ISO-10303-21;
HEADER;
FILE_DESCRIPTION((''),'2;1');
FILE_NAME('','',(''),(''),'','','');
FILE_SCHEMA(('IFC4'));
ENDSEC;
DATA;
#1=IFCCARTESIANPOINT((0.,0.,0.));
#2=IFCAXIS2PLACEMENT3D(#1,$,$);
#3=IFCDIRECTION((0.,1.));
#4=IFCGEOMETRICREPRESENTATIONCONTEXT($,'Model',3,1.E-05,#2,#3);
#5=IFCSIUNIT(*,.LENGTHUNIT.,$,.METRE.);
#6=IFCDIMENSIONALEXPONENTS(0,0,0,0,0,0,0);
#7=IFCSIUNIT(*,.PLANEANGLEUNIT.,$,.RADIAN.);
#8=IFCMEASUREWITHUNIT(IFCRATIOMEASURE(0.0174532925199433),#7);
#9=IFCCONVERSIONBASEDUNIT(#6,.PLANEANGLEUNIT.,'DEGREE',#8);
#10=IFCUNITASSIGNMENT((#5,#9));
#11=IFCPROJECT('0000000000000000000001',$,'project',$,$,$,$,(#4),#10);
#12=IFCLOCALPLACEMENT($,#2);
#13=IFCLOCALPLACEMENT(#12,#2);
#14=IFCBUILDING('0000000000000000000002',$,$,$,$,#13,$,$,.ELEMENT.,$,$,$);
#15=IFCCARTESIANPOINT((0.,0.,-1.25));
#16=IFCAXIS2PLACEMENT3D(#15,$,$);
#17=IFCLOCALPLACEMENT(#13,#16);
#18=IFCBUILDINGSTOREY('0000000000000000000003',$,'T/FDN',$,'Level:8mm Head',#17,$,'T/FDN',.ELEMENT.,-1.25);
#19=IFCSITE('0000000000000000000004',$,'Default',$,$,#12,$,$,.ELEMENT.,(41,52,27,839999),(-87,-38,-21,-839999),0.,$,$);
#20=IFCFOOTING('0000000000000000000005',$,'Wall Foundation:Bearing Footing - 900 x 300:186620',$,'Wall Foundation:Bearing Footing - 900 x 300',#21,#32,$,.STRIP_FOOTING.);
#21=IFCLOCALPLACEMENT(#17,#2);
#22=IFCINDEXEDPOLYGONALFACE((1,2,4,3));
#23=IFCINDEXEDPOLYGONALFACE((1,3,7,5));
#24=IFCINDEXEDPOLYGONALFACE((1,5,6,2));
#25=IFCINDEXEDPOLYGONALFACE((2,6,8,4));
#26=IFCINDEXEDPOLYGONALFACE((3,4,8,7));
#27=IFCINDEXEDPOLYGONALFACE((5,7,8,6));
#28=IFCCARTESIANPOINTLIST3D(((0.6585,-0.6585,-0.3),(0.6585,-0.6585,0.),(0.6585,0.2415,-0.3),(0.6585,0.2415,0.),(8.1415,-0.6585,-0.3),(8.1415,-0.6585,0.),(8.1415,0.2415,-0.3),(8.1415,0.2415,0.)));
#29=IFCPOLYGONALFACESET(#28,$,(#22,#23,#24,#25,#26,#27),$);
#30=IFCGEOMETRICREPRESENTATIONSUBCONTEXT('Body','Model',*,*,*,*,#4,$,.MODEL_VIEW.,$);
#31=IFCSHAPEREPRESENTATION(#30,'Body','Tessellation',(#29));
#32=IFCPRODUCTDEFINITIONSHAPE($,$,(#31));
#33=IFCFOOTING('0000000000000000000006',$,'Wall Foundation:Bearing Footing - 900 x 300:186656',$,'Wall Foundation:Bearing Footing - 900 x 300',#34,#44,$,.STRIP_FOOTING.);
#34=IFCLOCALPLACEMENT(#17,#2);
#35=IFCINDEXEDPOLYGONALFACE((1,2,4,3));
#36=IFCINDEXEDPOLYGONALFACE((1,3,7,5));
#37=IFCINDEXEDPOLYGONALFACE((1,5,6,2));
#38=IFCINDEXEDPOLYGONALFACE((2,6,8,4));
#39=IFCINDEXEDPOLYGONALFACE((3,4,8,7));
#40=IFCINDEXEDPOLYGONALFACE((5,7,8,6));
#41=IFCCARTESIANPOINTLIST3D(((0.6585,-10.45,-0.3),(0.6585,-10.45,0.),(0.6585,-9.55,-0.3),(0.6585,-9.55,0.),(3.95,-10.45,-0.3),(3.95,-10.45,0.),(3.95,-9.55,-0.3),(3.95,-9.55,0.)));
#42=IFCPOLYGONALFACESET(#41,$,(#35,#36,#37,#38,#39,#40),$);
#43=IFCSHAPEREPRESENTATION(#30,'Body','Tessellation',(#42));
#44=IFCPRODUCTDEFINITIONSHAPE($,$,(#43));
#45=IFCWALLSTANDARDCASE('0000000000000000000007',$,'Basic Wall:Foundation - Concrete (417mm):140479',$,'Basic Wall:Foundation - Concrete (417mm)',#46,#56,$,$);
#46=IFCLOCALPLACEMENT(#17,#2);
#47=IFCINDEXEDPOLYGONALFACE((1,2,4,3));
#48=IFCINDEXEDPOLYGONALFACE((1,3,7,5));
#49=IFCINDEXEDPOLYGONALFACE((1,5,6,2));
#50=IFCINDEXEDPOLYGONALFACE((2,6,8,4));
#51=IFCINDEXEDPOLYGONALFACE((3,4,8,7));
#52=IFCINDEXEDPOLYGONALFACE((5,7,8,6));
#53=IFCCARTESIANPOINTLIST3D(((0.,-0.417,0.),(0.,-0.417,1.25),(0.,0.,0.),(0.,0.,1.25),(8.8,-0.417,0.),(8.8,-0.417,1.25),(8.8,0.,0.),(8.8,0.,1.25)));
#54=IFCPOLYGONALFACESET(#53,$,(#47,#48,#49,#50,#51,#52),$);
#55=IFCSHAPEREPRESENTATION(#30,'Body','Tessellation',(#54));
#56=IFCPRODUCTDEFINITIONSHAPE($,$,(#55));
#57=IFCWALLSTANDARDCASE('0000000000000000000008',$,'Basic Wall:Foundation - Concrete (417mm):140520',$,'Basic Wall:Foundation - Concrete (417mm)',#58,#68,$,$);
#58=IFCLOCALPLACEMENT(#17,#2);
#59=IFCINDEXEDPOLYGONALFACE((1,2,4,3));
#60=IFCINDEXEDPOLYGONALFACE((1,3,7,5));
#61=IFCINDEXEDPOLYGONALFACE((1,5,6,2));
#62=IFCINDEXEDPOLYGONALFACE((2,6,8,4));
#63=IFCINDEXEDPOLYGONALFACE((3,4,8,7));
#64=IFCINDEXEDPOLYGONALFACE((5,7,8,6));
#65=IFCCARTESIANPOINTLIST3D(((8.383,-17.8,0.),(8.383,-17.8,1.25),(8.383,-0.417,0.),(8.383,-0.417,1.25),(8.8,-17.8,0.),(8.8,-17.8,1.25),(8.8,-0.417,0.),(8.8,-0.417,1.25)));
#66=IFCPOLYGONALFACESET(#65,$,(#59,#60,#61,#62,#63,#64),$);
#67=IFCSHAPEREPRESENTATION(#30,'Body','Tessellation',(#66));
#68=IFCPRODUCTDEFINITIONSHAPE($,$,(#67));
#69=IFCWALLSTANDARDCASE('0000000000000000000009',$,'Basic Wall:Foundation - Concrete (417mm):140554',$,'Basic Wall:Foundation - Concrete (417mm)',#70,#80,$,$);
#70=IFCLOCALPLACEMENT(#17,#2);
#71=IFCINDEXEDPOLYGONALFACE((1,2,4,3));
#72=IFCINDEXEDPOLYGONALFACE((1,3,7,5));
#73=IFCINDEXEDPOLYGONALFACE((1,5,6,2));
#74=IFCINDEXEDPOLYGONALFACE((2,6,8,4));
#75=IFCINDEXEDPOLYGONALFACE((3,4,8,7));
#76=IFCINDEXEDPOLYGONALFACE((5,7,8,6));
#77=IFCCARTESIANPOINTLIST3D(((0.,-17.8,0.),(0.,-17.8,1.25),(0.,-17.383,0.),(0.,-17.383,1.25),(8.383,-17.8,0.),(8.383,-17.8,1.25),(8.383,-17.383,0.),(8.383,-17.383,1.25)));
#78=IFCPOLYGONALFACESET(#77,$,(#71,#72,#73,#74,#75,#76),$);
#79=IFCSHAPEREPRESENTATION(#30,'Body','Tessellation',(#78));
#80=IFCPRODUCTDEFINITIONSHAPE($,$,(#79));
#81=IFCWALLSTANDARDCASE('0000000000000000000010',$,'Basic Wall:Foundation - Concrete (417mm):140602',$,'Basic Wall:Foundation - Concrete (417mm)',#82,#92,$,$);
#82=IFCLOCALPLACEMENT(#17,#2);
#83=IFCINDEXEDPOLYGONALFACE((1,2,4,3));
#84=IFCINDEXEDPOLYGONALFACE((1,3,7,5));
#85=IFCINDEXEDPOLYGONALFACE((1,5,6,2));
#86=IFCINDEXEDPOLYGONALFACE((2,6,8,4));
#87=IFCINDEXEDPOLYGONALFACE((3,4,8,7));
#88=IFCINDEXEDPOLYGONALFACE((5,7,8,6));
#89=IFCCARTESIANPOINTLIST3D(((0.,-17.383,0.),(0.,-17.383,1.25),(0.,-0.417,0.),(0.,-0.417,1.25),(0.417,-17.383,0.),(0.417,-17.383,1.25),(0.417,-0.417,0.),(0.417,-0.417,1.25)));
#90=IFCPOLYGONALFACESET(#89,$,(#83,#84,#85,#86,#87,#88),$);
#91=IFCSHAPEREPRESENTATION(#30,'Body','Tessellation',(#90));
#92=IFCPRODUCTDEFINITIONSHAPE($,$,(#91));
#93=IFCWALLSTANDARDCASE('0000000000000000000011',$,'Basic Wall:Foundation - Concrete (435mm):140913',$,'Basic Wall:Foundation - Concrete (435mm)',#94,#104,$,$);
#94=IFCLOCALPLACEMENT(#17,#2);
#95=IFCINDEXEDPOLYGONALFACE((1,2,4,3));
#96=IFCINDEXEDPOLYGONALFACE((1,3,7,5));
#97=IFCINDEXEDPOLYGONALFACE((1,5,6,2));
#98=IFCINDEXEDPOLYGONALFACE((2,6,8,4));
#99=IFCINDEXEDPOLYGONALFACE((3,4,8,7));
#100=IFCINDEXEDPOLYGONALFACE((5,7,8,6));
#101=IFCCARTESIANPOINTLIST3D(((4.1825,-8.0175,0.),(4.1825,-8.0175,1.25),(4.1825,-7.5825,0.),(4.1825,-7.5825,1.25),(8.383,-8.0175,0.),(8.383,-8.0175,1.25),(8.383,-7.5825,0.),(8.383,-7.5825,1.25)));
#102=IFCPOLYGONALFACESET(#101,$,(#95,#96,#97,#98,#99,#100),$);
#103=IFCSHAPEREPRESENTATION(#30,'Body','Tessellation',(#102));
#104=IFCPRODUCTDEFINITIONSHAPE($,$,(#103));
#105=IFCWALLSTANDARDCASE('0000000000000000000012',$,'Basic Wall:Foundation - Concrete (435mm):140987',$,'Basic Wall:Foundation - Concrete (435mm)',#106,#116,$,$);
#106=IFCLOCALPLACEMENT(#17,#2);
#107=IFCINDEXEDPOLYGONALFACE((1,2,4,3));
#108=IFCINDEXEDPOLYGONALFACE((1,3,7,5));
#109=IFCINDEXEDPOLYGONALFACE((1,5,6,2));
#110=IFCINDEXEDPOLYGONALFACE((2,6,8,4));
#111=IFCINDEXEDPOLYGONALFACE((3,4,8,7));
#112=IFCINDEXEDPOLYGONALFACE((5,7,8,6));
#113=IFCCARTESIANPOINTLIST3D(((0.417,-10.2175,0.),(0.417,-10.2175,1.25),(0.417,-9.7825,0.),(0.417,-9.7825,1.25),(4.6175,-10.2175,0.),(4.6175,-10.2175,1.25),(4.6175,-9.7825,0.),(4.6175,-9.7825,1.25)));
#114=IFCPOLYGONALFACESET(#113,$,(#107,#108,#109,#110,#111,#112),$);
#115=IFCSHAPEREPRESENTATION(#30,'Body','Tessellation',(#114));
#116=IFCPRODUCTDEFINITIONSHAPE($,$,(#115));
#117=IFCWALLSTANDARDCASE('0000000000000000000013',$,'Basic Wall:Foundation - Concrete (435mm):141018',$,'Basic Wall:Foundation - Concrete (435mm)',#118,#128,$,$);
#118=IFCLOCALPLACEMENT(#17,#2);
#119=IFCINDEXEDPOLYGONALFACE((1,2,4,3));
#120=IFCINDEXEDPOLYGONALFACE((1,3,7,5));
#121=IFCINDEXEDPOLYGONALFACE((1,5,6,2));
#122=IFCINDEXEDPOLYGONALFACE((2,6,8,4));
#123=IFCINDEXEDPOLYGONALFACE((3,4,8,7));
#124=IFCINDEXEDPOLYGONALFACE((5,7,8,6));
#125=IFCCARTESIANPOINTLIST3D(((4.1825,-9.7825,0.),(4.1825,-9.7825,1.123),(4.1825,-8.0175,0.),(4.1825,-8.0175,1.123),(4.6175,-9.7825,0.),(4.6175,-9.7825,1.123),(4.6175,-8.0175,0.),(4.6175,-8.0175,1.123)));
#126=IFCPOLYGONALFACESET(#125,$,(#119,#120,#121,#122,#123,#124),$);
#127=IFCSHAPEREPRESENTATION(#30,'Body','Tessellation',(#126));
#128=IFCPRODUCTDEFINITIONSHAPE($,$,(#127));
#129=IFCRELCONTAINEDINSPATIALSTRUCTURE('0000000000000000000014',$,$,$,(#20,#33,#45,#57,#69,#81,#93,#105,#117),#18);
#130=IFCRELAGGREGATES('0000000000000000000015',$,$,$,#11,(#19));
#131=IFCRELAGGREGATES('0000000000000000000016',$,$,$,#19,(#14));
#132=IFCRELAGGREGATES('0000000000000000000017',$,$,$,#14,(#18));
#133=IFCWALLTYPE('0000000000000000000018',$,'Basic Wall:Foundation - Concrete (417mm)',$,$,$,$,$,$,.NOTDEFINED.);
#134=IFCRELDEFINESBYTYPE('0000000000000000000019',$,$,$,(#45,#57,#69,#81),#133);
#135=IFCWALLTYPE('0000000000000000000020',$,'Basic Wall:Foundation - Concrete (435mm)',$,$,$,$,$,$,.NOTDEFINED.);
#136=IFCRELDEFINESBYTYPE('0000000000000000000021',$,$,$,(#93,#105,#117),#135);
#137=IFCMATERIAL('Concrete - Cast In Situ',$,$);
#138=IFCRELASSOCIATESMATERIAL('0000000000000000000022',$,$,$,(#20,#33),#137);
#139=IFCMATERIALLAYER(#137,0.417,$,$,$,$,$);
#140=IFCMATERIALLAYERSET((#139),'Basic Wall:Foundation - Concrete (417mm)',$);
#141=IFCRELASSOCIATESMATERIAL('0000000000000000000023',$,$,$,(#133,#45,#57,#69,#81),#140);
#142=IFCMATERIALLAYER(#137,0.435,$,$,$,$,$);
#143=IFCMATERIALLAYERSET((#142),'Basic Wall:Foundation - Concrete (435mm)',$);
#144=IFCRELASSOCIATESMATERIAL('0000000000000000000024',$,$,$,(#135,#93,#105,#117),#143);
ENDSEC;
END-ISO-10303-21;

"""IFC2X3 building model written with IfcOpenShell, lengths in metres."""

from ifc_helpers import new_model, entity, si_unit, converted_unit, direction, frame, frame_2d, origin, place, context, subcontext, project, spatial, rectangle, extrude, material, layer, layer_set, layer_usage, type_object, element, save


model = new_model("IFC2X3")

# Units and contexts
model_context = context("Model", 3, precision=1e-05, world=origin(), true_north=direction((0.0, 1.0)))
body_context = subcontext(model_context, "Body", "Model", "MODEL_VIEW")
ifc_project = project(units=[si_unit("LENGTHUNIT", "METRE"), converted_unit("PLANEANGLEUNIT", "DEGREE", entity("IfcRatioMeasure", 0.0174532925199433), si_unit("PLANEANGLEUNIT", "RADIAN"), dimensions=[0, 0, 0, 0, 0, 0, 0])], contexts=[model_context])

# Site, building, storey
site_placement = place(None, origin())
site = spatial("IfcSite", under=ifc_project, at=site_placement, Name="Default", CompositionType="ELEMENT", RefLatitude=(41, 52, 27, 839999), RefLongitude=(-87, -38, -21, -839999), RefElevation=0.0)
building_placement = place(site_placement, origin())
building = spatial("IfcBuilding", under=site, at=building_placement, CompositionType="ELEMENT")
storey_placement = place(building_placement, frame((0.0, 0.0, -1.25)))
storey = spatial("IfcBuildingStorey", under=building, at=storey_placement, Name="T/FDN", ObjectType="Level:8mm Head", LongName="T/FDN", CompositionType="ELEMENT", Elevation=-1.25)

# Footings
ifc_material = material(Name="Concrete - Cast In Situ")
footing_1_placement = place(storey_placement, origin())
element("IfcFooting", 1, at=footing_1_placement, inside=storey, material=ifc_material, Name="Wall Foundation:Bearing Footing - 900 x 300:186620", ObjectType="Wall Foundation:Bearing Footing - 900 x 300", PredefinedType="STRIP_FOOTING", context=body_context, shape_type="SweptSolid", body=[
    extrude(rectangle(XDim=7.483, YDim=0.9, at=frame_2d((0.0, 0.0), x_axis=(1.0, 0.0))), frame((4.4, -0.2085, -0.3), z_axis=(0.0, 0.0, 1.0), x_axis=(-1.0, 0.0, 0.0)), (0.0, 0.0, 1.0), 0.3),
])
footing_2_placement = place(storey_placement, origin())
element("IfcFooting", 2, at=footing_2_placement, inside=storey, material=ifc_material, Name="Wall Foundation:Bearing Footing - 900 x 300:186656", ObjectType="Wall Foundation:Bearing Footing - 900 x 300", PredefinedType="STRIP_FOOTING", context=body_context, shape_type="SweptSolid", body=[
    extrude(rectangle(XDim=3.2915, YDim=0.9, at=frame_2d((0.0, 0.0), x_axis=(1.0, 0.0))), frame((2.3043, -10.0, -0.3)), (0.0, 0.0, 1.0), 0.3),
])

# Walls
ifc_layer_1 = layer(ifc_material, 0.417)
ifc_layer_set_1 = layer_set([ifc_layer_1], Name="Basic Wall:Foundation - Concrete (417mm)")
ifc_layer_usage_1 = layer_usage(ifc_layer_set_1, "AXIS2", "NEGATIVE", 0.2085)
wall_type_1 = type_object("IfcWallType", Name="Basic Wall:Foundation - Concrete (417mm)", PredefinedType="NOTDEFINED", material=ifc_layer_set_1)
wall_1_placement = place(storey_placement, frame((0.0, -0.2085, 0.0)))
element("IfcWallStandardCase", 3, at=wall_1_placement, inside=storey, type_object=wall_type_1, material=ifc_layer_usage_1, Name="Basic Wall:Foundation - Concrete (417mm):140479", ObjectType="Basic Wall:Foundation - Concrete (417mm)", context=body_context, shape_type="SweptSolid", body=[
    extrude(rectangle(XDim=8.8, YDim=0.417, at=frame_2d((4.4, 0.0), x_axis=(-1.0, 0.0))), origin(), (0.0, 0.0, 1.0), 1.25),
])
ifc_layer_usage_2 = layer_usage(ifc_layer_set_1, "AXIS2", "NEGATIVE", 0.2085)
wall_2_placement = place(storey_placement, frame((8.5915, -0.417, 0.0), z_axis=(0.0, 0.0, 1.0), x_axis=(0.0, -1.0, 0.0)))
element("IfcWallStandardCase", 4, at=wall_2_placement, inside=storey, type_object=wall_type_1, material=ifc_layer_usage_2, Name="Basic Wall:Foundation - Concrete (417mm):140520", ObjectType="Basic Wall:Foundation - Concrete (417mm)", context=body_context, shape_type="SweptSolid", body=[
    extrude(rectangle(XDim=17.383, YDim=0.417, at=frame_2d((8.6915, 0.0), x_axis=(-1.0, 0.0))), origin(), (0.0, 0.0, 1.0), 1.25),
])
ifc_layer_usage_3 = layer_usage(ifc_layer_set_1, "AXIS2", "NEGATIVE", 0.2085)
wall_3_placement = place(storey_placement, frame((8.383, -17.5915, 0.0), z_axis=(0.0, 0.0, 1.0), x_axis=(-1.0, 0.0, 0.0)))
element("IfcWallStandardCase", 5, at=wall_3_placement, inside=storey, type_object=wall_type_1, material=ifc_layer_usage_3, Name="Basic Wall:Foundation - Concrete (417mm):140554", ObjectType="Basic Wall:Foundation - Concrete (417mm)", context=body_context, shape_type="SweptSolid", body=[
    extrude(rectangle(XDim=8.383, YDim=0.417, at=frame_2d((4.1915, 0.0), x_axis=(-1.0, 0.0))), origin(), (0.0, 0.0, 1.0), 1.25),
])
ifc_layer_usage_4 = layer_usage(ifc_layer_set_1, "AXIS2", "NEGATIVE", 0.2085)
wall_4_placement = place(storey_placement, frame((0.2085, -17.383, 0.0), z_axis=(0.0, 0.0, 1.0), x_axis=(0.0, 1.0, 0.0)))
element("IfcWallStandardCase", 6, at=wall_4_placement, inside=storey, type_object=wall_type_1, material=ifc_layer_usage_4, Name="Basic Wall:Foundation - Concrete (417mm):140602", ObjectType="Basic Wall:Foundation - Concrete (417mm)", context=body_context, shape_type="SweptSolid", body=[
    extrude(rectangle(XDim=16.966, YDim=0.417, at=frame_2d((8.483, 0.0), x_axis=(-1.0, 0.0))), origin(), (0.0, 0.0, 1.0), 1.25),
])
ifc_layer_2 = layer(ifc_material, 0.435)
ifc_layer_set_2 = layer_set([ifc_layer_2], Name="Basic Wall:Foundation - Concrete (435mm)")
ifc_layer_usage_5 = layer_usage(ifc_layer_set_2, "AXIS2", "NEGATIVE", 0.2175)
wall_type_2 = type_object("IfcWallType", Name="Basic Wall:Foundation - Concrete (435mm)", PredefinedType="NOTDEFINED", material=ifc_layer_set_2)
wall_5_placement = place(storey_placement, frame((8.383, -7.8, 0.0), z_axis=(0.0, 0.0, 1.0), x_axis=(-1.0, 0.0, 0.0)))
element("IfcWallStandardCase", 7, at=wall_5_placement, inside=storey, type_object=wall_type_2, material=ifc_layer_usage_5, Name="Basic Wall:Foundation - Concrete (435mm):140913", ObjectType="Basic Wall:Foundation - Concrete (435mm)", context=body_context, shape_type="SweptSolid", body=[
    extrude(rectangle(XDim=4.2005, YDim=0.435, at=frame_2d((2.1002, 0.0), x_axis=(-1.0, 0.0))), origin(), (0.0, 0.0, 1.0), 1.25),
])
ifc_layer_usage_6 = layer_usage(ifc_layer_set_2, "AXIS2", "NEGATIVE", 0.2175)
wall_6_placement = place(storey_placement, frame((0.417, -10.0, 0.0)))
element("IfcWallStandardCase", 8, at=wall_6_placement, inside=storey, type_object=wall_type_2, material=ifc_layer_usage_6, Name="Basic Wall:Foundation - Concrete (435mm):140987", ObjectType="Basic Wall:Foundation - Concrete (435mm)", context=body_context, shape_type="SweptSolid", body=[
    extrude(rectangle(XDim=4.2005, YDim=0.435, at=frame_2d((2.1002, 0.0), x_axis=(-1.0, 0.0))), origin(), (0.0, 0.0, 1.0), 1.25),
])
ifc_layer_usage_7 = layer_usage(ifc_layer_set_2, "AXIS2", "NEGATIVE", 0.2175)
wall_7_placement = place(storey_placement, frame((4.4, -9.7825, 0.0), z_axis=(0.0, 0.0, 1.0), x_axis=(0.0, 1.0, 0.0)))
element("IfcWallStandardCase", 9, at=wall_7_placement, inside=storey, type_object=wall_type_2, material=ifc_layer_usage_7, Name="Basic Wall:Foundation - Concrete (435mm):141018", ObjectType="Basic Wall:Foundation - Concrete (435mm)", context=body_context, shape_type="SweptSolid", body=[
    extrude(rectangle(XDim=1.765, YDim=0.435, at=frame_2d((0.8825, 0.0), x_axis=(-1.0, 0.0))), origin(), (0.0, 0.0, 1.0), 1.123),
])

save(model, "model.ifc")
